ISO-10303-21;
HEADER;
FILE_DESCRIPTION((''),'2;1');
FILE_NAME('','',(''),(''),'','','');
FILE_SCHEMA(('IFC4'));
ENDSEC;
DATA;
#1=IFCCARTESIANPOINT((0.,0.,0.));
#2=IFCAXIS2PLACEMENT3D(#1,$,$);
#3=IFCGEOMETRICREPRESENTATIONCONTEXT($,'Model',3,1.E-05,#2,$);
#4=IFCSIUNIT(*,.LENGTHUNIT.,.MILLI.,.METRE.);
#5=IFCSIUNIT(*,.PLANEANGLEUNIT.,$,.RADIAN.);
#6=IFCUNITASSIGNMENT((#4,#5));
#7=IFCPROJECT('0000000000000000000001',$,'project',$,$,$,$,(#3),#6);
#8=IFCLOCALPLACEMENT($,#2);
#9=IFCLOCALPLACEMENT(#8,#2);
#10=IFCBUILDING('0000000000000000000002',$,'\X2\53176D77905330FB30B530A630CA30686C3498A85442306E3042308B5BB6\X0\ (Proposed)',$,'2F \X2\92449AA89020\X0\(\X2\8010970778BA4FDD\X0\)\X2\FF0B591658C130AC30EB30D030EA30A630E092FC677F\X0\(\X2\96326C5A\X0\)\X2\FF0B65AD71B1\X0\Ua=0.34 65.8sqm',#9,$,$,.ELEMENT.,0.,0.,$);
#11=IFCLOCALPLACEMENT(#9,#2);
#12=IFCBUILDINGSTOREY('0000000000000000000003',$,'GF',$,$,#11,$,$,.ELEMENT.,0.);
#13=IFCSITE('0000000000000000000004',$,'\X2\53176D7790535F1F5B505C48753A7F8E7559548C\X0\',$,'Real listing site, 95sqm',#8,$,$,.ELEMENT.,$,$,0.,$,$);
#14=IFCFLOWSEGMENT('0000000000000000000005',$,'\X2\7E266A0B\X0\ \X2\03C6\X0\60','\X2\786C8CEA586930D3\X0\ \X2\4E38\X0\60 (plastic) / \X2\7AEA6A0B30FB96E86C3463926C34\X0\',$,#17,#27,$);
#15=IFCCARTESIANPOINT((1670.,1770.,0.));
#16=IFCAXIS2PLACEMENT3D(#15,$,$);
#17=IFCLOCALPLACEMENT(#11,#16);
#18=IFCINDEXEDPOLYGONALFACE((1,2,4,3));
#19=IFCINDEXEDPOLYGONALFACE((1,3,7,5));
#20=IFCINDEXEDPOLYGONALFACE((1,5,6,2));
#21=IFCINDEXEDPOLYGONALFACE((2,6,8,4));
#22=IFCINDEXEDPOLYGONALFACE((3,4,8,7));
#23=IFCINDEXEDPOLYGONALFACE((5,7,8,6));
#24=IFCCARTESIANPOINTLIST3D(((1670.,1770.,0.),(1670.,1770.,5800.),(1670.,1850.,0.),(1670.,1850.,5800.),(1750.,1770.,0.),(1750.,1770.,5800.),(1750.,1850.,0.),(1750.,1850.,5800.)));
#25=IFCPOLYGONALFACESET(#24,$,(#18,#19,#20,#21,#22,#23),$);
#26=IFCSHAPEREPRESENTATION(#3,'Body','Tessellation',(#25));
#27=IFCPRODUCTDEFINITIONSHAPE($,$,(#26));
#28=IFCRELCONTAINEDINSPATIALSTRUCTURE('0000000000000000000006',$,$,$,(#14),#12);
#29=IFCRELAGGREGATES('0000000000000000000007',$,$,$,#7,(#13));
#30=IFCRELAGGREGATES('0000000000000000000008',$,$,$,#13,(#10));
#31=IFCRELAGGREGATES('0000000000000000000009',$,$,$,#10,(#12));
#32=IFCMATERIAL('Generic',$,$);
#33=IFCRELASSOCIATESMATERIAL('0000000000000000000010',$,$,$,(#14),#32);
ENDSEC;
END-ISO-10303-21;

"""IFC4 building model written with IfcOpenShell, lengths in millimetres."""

from ifc_helpers import new_model, si_unit, frame, frame_2d, origin, place, context, project, spatial, rectangle, extrude, material, element, save


model = new_model("IFC4")

# Units and contexts
model_context = context("Model", 3, precision=1e-05, world=origin())
ifc_project = project(units=[si_unit("LENGTHUNIT", "METRE", prefix="MILLI"), si_unit("PLANEANGLEUNIT", "RADIAN")], contexts=[model_context])

# Site, building, storey
site_placement = place(None, origin())
site = spatial("IfcSite", under=ifc_project, at=site_placement, Name="北海道弟子屈町美留和", ObjectType="Real listing site, 95sqm", CompositionType="ELEMENT", RefElevation=0.0)
building_placement = place(site_placement, origin())
building = spatial("IfcBuilding", under=site, at=building_placement, Name="北海道・サウナと水風呂のある家 (Proposed)", ObjectType="2F 鉄骨造(耐震確保)＋外壁ガルバリウム鋼板(防汚)＋断熱Ua=0.34 65.8sqm", CompositionType="ELEMENT", ElevationOfRefHeight=0.0, ElevationOfTerrain=0.0)
storey_placement = place(building_placement, origin())
storey = spatial("IfcBuildingStorey", under=building, at=storey_placement, Name="GF", CompositionType="ELEMENT", Elevation=0.0)

# Shared definitions
ifc_material_1 = material(Name="Generic")

# Flow segment
flow_segment_1_placement = place(storey_placement, frame((1670.0, 1770.0, 0.0)))
element("IfcFlowSegment", 1, at=flow_segment_1_placement, inside=storey, material=ifc_material_1, Name="縦樋 φ60", Description="硬質塩ビ 丸60 (plastic) / 竪樋・雨水排水", context=model_context, shape_type="SweptSolid", body=[
    extrude(rectangle(XDim=80.0, YDim=80.0, at=frame_2d((40.0, 40.0))), frame((1670.0, 1770.0, 0.0)), (0.0, 0.0, 1.0), 5800.0),
])

save(model, "model.ifc")
